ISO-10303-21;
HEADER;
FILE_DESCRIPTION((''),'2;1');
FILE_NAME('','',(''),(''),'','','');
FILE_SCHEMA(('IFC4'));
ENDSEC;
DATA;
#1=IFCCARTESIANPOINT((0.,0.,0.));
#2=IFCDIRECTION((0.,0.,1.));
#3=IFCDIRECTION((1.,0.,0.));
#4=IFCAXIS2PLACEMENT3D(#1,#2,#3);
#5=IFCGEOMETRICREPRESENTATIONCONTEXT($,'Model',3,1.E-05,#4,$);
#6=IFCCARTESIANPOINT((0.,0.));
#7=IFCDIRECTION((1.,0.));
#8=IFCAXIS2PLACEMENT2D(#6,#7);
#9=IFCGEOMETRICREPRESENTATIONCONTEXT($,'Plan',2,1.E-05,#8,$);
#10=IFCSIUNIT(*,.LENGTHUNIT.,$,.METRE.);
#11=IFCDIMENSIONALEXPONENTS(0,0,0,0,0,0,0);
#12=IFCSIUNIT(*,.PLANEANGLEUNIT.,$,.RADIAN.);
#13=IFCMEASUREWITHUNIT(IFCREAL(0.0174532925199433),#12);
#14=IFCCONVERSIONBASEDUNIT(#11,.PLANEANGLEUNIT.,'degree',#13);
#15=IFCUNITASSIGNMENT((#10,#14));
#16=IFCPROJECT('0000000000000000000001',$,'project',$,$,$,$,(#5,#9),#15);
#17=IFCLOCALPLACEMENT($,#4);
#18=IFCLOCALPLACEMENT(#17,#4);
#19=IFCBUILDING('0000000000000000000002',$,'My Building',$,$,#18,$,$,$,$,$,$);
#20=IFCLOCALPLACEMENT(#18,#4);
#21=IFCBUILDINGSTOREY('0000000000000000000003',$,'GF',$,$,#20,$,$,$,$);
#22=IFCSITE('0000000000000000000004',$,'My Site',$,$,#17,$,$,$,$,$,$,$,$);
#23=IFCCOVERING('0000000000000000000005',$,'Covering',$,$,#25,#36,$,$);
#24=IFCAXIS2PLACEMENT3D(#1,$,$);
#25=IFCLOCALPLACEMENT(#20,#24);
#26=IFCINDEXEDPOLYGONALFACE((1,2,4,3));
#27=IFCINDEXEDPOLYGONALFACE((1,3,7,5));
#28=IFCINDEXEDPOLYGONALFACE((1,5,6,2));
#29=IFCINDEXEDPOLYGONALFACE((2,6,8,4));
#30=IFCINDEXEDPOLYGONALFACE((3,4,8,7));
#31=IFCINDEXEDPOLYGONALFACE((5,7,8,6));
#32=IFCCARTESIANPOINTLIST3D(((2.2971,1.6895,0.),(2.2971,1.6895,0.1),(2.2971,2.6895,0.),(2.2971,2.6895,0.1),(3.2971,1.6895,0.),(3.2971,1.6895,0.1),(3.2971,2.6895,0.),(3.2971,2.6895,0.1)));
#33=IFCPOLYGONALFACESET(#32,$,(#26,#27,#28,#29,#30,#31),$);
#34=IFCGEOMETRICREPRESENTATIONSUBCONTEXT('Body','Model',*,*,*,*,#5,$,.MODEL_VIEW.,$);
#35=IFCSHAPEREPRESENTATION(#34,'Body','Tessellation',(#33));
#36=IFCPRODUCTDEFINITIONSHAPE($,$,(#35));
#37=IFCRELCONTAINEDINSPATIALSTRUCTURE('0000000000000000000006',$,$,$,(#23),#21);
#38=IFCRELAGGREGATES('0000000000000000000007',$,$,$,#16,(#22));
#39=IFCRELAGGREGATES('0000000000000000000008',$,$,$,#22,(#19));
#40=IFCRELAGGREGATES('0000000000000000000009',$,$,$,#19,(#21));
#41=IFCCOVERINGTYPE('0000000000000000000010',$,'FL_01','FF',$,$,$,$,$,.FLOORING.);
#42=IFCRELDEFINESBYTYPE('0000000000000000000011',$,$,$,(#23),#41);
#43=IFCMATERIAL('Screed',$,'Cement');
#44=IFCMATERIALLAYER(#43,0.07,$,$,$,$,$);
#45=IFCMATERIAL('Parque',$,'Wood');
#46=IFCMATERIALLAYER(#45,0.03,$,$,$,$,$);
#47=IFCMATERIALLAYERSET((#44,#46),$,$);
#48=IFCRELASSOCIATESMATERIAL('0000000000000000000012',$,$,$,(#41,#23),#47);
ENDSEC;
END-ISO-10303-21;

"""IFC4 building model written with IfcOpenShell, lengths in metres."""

from ifc_helpers import new_model, entity, si_unit, converted_unit, frame, origin_with_axes, origin_2d_with_axis, place, context, subcontext, project, spatial, indexed_curve, outline, extrude, material, layer, layer_set, layer_usage, type_object, element, save


model = new_model("IFC4")

# Units and contexts
model_context = context("Model", 3, precision=1e-05, world=origin_with_axes())
plan_context = context("Plan", 2, precision=1e-05, world=origin_2d_with_axis())
body_context_1 = subcontext(model_context, "Body", "Model", "MODEL_VIEW")
ifc_project = project(units=[si_unit("LENGTHUNIT", "METRE"), converted_unit("PLANEANGLEUNIT", "degree", entity("IfcReal", 0.0174532925199433), si_unit("PLANEANGLEUNIT", "RADIAN"), dimensions=[0, 0, 0, 0, 0, 0, 0])], contexts=[model_context, plan_context])

# Site, building, storey
site_placement = place(None, origin_with_axes())
site = spatial("IfcSite", under=ifc_project, at=site_placement, Name="My Site")
building_placement = place(site_placement, origin_with_axes())
building = spatial("IfcBuilding", under=site, at=building_placement, Name="My Building")
storey_placement = place(building_placement, origin_with_axes())
storey = spatial("IfcBuildingStorey", under=building, at=storey_placement, Name="GF")

# Covering
ifc_material_1 = material(Name="Screed", Category="Cement")
ifc_layer_1 = layer(ifc_material_1, 0.07)
ifc_material_2 = material(Name="Parque", Category="Wood")
ifc_layer_2 = layer(ifc_material_2, 0.03)
ifc_layer_set_1 = layer_set([ifc_layer_1, ifc_layer_2])
ifc_layer_usage_1 = layer_usage(ifc_layer_set_1, "AXIS3", "POSITIVE", 0.0)
covering_type = type_object("IfcCoveringType", Name="FL_01", Description="FF", PredefinedType="FLOORING", material=ifc_layer_set_1)
covering_placement = place(storey_placement, frame((2.2971, 1.6895, 0.0), z_axis=(0.0, 0.0, 1.0), x_axis=(1.0, 0.0, 0.0)))
element("IfcCovering", 1, at=covering_placement, inside=storey, type_object=covering_type, material=ifc_layer_usage_1, Name="Covering", context=body_context_1, shape_type="SweptSolid", body=[
    extrude(outline(indexed_curve([(0.0, 0.0), (1.0, 0.0), (1.0, 1.0), (0.0, 1.0), (0.0, 0.0)])), None, (0.0, 0.0, 1.0), 0.1),
])

save(model, "model.ifc")
